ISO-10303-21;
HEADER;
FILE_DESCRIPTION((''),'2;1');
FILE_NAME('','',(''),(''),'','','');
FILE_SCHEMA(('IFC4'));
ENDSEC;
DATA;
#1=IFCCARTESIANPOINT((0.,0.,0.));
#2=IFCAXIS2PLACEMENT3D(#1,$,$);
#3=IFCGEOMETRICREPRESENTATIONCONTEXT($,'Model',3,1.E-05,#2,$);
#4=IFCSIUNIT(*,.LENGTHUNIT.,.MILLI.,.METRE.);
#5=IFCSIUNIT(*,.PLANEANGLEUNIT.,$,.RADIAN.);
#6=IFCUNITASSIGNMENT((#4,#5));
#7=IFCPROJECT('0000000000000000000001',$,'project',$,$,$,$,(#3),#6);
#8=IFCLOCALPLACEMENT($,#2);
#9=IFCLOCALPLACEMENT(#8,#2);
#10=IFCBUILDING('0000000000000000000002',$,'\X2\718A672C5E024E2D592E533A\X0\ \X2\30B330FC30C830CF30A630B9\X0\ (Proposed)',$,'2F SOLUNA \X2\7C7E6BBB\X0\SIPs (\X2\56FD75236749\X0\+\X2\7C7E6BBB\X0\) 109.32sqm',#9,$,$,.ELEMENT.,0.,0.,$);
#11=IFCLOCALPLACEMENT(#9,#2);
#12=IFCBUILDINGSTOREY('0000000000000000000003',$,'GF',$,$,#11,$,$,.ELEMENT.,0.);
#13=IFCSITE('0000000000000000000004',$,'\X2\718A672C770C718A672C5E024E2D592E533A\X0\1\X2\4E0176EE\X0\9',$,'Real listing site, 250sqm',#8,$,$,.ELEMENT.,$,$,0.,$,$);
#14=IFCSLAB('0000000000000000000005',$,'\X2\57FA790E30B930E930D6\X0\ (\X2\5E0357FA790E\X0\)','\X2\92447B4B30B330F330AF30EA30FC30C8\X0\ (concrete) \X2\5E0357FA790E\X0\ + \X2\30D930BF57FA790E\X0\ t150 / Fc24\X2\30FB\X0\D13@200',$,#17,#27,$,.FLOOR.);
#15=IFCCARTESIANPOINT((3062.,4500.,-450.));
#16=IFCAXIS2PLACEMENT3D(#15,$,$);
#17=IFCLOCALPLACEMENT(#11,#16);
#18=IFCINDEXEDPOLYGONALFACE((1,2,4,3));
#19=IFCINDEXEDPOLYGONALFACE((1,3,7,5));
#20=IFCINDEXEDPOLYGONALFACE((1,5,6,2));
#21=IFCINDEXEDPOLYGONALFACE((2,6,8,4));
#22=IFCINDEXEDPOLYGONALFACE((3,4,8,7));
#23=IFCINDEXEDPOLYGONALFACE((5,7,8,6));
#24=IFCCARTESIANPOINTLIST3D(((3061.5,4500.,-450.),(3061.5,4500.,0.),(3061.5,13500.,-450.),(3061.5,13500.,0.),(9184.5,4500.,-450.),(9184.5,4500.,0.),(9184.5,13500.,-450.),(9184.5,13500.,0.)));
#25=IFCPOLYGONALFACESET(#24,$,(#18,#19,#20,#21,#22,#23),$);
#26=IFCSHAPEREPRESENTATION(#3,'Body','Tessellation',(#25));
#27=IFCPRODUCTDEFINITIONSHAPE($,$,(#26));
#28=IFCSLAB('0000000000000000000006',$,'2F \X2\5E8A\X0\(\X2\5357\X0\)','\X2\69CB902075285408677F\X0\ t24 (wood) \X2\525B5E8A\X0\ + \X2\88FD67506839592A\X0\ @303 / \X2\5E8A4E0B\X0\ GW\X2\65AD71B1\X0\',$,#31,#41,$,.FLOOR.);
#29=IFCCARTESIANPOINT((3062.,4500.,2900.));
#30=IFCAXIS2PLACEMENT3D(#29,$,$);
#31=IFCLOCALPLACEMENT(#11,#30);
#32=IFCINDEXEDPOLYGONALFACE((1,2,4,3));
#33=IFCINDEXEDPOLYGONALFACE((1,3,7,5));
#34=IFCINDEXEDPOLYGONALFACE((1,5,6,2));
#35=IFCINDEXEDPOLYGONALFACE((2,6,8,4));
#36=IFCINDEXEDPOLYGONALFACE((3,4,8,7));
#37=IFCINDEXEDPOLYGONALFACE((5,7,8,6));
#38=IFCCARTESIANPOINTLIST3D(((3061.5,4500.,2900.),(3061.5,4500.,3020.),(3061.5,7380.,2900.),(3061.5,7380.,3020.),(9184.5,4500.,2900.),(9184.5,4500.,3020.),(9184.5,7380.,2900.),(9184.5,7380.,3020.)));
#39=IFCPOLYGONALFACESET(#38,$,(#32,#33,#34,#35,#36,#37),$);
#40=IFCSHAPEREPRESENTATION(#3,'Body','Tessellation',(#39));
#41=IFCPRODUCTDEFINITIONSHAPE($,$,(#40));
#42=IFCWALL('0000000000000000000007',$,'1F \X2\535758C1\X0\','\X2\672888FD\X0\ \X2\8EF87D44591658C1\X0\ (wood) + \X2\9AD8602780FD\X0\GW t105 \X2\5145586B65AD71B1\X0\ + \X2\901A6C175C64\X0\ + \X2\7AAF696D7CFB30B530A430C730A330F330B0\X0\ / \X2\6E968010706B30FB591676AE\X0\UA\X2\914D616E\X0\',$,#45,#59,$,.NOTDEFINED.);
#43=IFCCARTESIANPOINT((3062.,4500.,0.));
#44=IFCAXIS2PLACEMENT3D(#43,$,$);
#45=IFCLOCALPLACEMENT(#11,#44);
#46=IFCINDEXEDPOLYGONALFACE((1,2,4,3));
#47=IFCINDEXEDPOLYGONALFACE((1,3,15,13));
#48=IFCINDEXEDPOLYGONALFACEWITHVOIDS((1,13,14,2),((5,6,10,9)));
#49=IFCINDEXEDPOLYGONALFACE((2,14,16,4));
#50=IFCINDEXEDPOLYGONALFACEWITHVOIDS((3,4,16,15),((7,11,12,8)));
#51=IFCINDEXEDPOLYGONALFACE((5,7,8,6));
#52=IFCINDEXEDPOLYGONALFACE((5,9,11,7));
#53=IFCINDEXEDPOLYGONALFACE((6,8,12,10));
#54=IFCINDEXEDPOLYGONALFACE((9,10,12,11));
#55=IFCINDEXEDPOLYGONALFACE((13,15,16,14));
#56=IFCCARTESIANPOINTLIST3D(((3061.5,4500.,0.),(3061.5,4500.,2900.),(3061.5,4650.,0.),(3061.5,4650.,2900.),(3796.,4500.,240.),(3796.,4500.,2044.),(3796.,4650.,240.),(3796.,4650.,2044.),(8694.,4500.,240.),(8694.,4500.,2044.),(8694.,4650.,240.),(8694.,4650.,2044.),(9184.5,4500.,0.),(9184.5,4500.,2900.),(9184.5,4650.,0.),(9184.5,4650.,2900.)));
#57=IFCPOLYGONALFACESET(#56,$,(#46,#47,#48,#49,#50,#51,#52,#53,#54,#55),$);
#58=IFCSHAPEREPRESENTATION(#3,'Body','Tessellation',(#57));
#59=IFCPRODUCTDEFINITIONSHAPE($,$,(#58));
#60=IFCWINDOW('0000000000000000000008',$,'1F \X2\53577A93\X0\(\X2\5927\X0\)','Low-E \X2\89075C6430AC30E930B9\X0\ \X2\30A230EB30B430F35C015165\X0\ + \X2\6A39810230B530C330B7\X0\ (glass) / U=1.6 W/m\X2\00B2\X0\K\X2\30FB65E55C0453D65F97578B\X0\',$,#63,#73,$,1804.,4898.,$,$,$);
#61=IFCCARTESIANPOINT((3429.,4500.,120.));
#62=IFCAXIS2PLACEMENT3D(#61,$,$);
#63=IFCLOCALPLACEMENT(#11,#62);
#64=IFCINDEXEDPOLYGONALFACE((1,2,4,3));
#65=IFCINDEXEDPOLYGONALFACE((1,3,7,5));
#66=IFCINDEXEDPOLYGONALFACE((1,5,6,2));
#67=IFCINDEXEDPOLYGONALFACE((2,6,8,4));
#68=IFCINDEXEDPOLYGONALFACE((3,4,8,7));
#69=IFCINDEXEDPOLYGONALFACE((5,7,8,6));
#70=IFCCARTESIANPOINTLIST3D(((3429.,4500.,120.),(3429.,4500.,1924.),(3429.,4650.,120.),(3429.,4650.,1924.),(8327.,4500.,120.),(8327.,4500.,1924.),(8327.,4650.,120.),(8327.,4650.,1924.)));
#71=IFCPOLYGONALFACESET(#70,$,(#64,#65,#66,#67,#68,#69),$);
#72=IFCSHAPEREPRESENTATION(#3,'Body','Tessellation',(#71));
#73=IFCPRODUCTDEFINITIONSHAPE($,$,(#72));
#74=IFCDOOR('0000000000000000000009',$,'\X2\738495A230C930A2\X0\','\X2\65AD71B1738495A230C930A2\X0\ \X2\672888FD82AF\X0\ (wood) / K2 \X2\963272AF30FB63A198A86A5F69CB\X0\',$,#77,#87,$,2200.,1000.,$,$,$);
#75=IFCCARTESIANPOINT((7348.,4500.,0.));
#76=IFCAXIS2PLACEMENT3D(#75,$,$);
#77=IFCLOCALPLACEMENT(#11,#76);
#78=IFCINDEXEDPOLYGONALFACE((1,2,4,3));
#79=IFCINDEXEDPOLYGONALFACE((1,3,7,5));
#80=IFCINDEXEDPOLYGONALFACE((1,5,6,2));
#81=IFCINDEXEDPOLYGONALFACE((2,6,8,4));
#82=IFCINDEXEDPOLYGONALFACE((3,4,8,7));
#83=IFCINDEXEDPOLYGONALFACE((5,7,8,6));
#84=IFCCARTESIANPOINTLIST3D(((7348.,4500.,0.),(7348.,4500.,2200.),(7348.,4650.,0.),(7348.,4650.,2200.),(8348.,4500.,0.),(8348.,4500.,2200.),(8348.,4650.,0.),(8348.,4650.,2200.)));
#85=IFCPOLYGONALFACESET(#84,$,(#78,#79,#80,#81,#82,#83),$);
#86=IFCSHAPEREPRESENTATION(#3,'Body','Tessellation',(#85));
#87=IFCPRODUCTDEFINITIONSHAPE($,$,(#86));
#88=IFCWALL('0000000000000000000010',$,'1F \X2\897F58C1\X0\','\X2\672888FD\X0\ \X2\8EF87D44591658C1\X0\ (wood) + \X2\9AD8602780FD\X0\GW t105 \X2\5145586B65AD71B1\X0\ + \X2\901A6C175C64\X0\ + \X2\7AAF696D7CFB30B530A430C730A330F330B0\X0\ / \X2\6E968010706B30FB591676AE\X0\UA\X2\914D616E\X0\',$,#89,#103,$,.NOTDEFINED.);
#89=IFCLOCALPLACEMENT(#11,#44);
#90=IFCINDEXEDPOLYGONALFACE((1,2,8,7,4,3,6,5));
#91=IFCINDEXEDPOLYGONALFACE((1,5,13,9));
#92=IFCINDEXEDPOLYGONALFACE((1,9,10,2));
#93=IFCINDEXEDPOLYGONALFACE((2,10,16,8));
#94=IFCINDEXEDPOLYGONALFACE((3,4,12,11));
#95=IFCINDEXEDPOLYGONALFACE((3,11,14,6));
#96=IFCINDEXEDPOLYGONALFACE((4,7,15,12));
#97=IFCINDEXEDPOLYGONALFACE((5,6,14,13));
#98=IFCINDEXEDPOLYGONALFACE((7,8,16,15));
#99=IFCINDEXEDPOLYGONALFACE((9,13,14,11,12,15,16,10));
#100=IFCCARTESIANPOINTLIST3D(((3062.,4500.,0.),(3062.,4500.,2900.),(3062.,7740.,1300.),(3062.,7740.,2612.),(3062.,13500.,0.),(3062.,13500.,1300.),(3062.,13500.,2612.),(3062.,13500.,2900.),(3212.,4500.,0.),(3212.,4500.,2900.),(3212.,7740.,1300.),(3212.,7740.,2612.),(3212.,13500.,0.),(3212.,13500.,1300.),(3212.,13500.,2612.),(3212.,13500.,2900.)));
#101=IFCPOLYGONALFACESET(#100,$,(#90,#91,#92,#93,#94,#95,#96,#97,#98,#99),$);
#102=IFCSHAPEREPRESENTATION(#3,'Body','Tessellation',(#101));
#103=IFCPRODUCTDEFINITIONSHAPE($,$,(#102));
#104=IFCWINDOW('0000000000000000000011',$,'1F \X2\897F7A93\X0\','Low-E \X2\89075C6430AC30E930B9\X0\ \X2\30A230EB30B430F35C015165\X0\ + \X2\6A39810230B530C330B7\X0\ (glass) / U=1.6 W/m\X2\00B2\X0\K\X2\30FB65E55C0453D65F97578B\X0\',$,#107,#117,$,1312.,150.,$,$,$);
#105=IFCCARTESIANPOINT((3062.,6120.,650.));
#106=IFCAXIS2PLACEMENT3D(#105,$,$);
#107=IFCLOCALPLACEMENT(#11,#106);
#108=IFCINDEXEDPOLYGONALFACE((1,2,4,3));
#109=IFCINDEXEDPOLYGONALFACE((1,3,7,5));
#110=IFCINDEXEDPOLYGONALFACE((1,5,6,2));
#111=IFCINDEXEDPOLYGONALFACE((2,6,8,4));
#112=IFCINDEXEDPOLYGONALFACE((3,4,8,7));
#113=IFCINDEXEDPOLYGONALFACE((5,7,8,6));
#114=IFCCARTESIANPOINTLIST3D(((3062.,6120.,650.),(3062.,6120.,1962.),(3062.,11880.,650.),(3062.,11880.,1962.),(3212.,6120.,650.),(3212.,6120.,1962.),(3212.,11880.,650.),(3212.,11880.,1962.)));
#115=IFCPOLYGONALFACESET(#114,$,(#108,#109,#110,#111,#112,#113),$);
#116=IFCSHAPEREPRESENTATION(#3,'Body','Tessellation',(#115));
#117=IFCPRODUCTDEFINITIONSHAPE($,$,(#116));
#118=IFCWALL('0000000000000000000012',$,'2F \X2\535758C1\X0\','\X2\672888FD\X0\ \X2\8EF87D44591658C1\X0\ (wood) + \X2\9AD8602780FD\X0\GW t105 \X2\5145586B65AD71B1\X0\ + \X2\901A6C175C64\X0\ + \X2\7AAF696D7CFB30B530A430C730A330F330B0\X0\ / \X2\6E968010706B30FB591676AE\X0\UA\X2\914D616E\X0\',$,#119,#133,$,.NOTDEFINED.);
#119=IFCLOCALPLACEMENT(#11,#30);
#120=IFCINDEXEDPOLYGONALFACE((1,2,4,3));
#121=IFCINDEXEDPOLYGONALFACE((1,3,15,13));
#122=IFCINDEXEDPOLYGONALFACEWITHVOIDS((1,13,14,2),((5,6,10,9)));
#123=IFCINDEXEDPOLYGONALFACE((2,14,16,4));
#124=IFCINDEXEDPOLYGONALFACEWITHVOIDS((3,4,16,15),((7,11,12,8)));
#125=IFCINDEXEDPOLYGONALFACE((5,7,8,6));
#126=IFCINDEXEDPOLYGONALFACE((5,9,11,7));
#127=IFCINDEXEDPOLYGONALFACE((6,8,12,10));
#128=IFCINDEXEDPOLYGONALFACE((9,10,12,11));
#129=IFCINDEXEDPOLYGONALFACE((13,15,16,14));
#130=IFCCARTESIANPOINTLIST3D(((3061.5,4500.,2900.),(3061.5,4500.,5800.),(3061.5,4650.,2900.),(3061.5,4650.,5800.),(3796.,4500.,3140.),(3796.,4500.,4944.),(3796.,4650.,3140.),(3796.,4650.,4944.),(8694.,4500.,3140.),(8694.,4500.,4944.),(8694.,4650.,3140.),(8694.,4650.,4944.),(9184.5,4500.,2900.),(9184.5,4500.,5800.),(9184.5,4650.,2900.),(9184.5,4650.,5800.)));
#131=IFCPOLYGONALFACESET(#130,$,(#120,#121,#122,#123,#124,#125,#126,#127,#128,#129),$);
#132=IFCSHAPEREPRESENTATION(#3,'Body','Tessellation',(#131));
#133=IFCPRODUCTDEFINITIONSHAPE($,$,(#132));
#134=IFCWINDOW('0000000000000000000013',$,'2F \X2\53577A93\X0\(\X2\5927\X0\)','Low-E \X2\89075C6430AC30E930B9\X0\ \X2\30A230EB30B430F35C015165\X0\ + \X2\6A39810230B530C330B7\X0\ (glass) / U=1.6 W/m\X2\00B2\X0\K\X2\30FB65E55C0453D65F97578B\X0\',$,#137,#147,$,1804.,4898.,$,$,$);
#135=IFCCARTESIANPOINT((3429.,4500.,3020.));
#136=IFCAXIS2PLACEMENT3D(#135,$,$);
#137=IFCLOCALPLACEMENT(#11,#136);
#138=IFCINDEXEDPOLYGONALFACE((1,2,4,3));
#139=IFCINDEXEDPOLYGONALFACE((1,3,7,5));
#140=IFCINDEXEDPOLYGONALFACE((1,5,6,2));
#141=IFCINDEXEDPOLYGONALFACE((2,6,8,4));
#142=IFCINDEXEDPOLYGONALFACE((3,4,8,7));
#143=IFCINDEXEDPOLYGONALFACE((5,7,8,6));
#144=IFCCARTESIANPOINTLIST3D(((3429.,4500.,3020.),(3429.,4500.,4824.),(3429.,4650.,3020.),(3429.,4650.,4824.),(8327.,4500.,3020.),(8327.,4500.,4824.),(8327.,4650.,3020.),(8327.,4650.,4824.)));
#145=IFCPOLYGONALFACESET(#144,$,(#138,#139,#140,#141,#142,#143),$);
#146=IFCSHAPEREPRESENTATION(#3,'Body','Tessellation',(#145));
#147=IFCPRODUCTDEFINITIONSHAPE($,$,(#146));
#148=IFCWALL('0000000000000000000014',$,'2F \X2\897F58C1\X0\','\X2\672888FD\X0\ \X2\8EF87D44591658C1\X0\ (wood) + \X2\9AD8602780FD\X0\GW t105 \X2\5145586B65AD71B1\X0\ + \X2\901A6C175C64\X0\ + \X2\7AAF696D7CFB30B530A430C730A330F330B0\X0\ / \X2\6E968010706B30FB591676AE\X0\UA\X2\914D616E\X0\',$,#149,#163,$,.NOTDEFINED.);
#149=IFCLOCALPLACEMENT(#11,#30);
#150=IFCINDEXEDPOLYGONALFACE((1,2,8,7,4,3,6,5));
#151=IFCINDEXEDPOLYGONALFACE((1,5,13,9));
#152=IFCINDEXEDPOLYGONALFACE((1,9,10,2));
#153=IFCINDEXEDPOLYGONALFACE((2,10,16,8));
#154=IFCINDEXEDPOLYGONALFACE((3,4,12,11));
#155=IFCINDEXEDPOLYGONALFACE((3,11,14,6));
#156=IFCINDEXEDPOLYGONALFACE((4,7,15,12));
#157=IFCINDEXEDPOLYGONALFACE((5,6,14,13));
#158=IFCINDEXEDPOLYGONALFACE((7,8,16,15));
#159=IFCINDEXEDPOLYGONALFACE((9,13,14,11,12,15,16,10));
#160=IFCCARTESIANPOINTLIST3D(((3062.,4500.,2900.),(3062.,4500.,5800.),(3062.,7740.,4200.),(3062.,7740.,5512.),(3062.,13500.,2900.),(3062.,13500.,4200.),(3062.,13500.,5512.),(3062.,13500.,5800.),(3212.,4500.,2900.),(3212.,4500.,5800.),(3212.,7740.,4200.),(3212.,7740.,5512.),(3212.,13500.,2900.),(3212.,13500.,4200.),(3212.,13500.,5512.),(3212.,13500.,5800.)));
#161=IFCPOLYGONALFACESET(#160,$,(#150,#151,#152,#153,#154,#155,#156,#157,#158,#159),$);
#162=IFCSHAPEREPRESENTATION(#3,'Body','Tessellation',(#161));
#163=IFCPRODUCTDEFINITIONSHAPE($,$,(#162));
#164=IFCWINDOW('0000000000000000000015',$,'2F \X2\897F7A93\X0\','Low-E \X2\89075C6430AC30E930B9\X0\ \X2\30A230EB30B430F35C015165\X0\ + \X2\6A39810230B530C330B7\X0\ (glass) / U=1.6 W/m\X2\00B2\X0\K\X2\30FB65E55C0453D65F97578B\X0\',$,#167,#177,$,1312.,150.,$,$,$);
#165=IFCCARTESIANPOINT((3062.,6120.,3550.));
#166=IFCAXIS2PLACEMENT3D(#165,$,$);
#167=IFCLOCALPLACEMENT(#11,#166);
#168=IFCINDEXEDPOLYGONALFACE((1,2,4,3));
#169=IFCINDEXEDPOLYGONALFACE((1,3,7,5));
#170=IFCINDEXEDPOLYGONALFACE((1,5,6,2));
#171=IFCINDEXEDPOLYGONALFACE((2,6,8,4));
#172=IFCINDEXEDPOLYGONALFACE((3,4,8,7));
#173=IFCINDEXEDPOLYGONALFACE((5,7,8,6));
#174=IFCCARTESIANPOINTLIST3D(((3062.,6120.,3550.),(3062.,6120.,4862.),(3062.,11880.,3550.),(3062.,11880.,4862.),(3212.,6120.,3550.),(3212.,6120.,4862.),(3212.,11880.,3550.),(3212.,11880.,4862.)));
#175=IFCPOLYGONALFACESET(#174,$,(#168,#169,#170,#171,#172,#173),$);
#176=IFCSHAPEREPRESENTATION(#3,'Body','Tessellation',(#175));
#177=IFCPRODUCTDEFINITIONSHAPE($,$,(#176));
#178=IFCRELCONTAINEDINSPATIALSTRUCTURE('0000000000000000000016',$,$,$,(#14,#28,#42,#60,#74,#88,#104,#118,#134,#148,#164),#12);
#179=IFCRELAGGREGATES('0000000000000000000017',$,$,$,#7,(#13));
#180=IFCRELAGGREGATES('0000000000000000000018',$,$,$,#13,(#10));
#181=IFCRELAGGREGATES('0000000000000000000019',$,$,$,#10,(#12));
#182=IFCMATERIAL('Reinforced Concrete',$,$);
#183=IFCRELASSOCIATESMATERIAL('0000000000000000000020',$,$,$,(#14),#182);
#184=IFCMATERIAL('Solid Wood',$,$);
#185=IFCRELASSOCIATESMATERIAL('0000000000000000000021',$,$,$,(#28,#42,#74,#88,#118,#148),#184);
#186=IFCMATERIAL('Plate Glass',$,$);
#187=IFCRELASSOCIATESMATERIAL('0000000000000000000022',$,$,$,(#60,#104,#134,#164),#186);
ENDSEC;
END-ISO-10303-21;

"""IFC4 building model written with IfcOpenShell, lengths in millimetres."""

from ifc_helpers import new_model, si_unit, frame, frame_2d, origin, place, context, project, spatial, rectangle, extrude, material, element, fill, save


model = new_model("IFC4")

# Units and contexts
model_context = context("Model", 3, precision=1e-05, world=origin())
ifc_project = project(units=[si_unit("LENGTHUNIT", "METRE", prefix="MILLI"), si_unit("PLANEANGLEUNIT", "RADIAN")], contexts=[model_context])

# Site, building, storey
site_placement = place(None, origin())
site = spatial("IfcSite", under=ifc_project, at=site_placement, Name="熊本県熊本市中央区1丁目9", ObjectType="Real listing site, 250sqm", CompositionType="ELEMENT", RefElevation=0.0)
building_placement = place(site_placement, origin())
building = spatial("IfcBuilding", under=site, at=building_placement, Name="熊本市中央区 コートハウス (Proposed)", ObjectType="2F SOLUNA 籾殻SIPs (国産杉+籾殻) 109.32sqm", CompositionType="ELEMENT", ElevationOfRefHeight=0.0, ElevationOfTerrain=0.0)
storey_placement = place(building_placement, origin())
storey = spatial("IfcBuildingStorey", under=building, at=storey_placement, Name="GF", CompositionType="ELEMENT", Elevation=0.0)

# Slabs
ifc_material_1 = material(Name="Reinforced Concrete")
slab_1_placement = place(storey_placement, frame((3062.0, 4500.0, -450.0)))
element("IfcSlab", 1, at=slab_1_placement, inside=storey, material=ifc_material_1, Name="基礎スラブ (布基礎)", Description="鉄筋コンクリート (concrete) 布基礎 + ベタ基礎 t150 / Fc24・D13@200", PredefinedType="FLOOR", context=model_context, shape_type="SweptSolid", body=[
    extrude(rectangle(XDim=6123.0, YDim=9000.0, at=frame_2d((3061.0, 4500.0))), frame((3062.0, 4500.0, -450.0)), (0.0, 0.0, 1.0), 450.0),
])
ifc_material_2 = material(Name="Solid Wood")
slab_2_placement = place(storey_placement, frame((3062.0, 4500.0, 2900.0)))
element("IfcSlab", 2, at=slab_2_placement, inside=storey, material=ifc_material_2, Name="2F 床(南)", Description="構造用合板 t24 (wood) 剛床 + 製材根太 @303 / 床下 GW断熱", PredefinedType="FLOOR", context=model_context, shape_type="SweptSolid", body=[
    extrude(rectangle(XDim=6123.0, YDim=2880.0, at=frame_2d((3061.0, 1440.0))), frame((3062.0, 4500.0, 2900.0)), (0.0, 0.0, 1.0), 120.0),
])

# Wall, openings, window, door
wall_1_placement = place(storey_placement, frame((3062.0, 4500.0, 0.0)))
wall_1 = element("IfcWall", 3, at=wall_1_placement, inside=storey, material=ifc_material_2, Name="1F 南壁", Description="木製 軸組外壁 (wood) + 高性能GW t105 充填断熱 + 通気層 + 窯業系サイディング / 準耐火・外皮UA配慮", PredefinedType="NOTDEFINED", context=model_context, shape_type="SweptSolid", body=[
    extrude(rectangle(XDim=6123.0, YDim=150.0, at=frame_2d((3061.0, 75.0))), frame((3062.0, 4500.0, 0.0)), (0.0, 0.0, 1.0), 2900.0),
])
opening_1_placement = place(storey_placement, frame((3429.0, 4500.0, 120.0)))
opening_1 = element("IfcOpeningElement", 4, at=opening_1_placement, cuts=wall_1, PredefinedType="NOTDEFINED", context=model_context, shape_type="SweptSolid", body=[
    extrude(rectangle(XDim=4898.0, YDim=150.0, at=frame_2d((2449.0, 75.0))), frame((3429.0, 4500.0, 120.0)), (0.0, 0.0, 1.0), 1804.0),
])
opening_2_placement = place(storey_placement, frame((7348.0, 4500.0, 0.0)))
opening_2 = element("IfcOpeningElement", 5, at=opening_2_placement, cuts=wall_1, PredefinedType="NOTDEFINED", context=model_context, shape_type="SweptSolid", body=[
    extrude(rectangle(XDim=1000.0, YDim=150.0, at=frame_2d((500.0, 75.0))), frame((7348.0, 4500.0, 0.0)), (0.0, 0.0, 1.0), 2200.0),
])
ifc_material_3 = material(Name="Plate Glass")
window_1_placement = place(storey_placement, frame((3429.0, 4500.0, 120.0)))
window_1 = element("IfcWindow", 6, at=window_1_placement, inside=storey, material=ifc_material_3, Name="1F 南窓(大)", Description="Low-E 複層ガラス アルゴン封入 + 樹脂サッシ (glass) / U=1.6 W/m²K・日射取得型", OverallHeight=1804.0, OverallWidth=4898.0, context=model_context, shape_type="SweptSolid", body=[
    extrude(rectangle(XDim=4898.0, YDim=150.0, at=frame_2d((2449.0, 75.0))), frame((3429.0, 4500.0, 120.0)), (0.0, 0.0, 1.0), 1804.0),
])
fill(opening_1, window_1)
door_placement = place(storey_placement, frame((7348.0, 4500.0, 0.0)))
door = element("IfcDoor", 7, at=door_placement, inside=storey, material=ifc_material_2, Name="玄関ドア", Description="断熱玄関ドア 木製芯 (wood) / K2 防犯・採風機構", OverallHeight=2200.0, OverallWidth=1000.0, context=model_context, shape_type="SweptSolid", body=[
    extrude(rectangle(XDim=1000.0, YDim=150.0, at=frame_2d((500.0, 75.0))), frame((7348.0, 4500.0, 0.0)), (0.0, 0.0, 1.0), 2200.0),
])
fill(opening_2, door)

# Walls, openings, windows
wall_2_placement = place(storey_placement, frame((3062.0, 4500.0, 0.0)))
wall_2 = element("IfcWall", 8, at=wall_2_placement, inside=storey, material=ifc_material_2, Name="1F 西壁", Description="木製 軸組外壁 (wood) + 高性能GW t105 充填断熱 + 通気層 + 窯業系サイディング / 準耐火・外皮UA配慮", PredefinedType="NOTDEFINED", context=model_context, shape_type="SweptSolid", body=[
    extrude(rectangle(XDim=150.0, YDim=9000.0, at=frame_2d((75.0, 4500.0))), frame((3062.0, 4500.0, 0.0)), (0.0, 0.0, 1.0), 2900.0),
])
opening_3_placement = place(storey_placement, frame((3062.0, 6120.0, 650.0)))
opening_3 = element("IfcOpeningElement", 9, at=opening_3_placement, cuts=wall_2, PredefinedType="NOTDEFINED", context=model_context, shape_type="SweptSolid", body=[
    extrude(rectangle(XDim=150.0, YDim=5760.0, at=frame_2d((75.0, 2880.0))), frame((3062.0, 6120.0, 650.0)), (0.0, 0.0, 1.0), 1312.0),
])
window_2_placement = place(storey_placement, frame((3062.0, 6120.0, 650.0)))
window_2 = element("IfcWindow", 10, at=window_2_placement, inside=storey, material=ifc_material_3, Name="1F 西窓", Description="Low-E 複層ガラス アルゴン封入 + 樹脂サッシ (glass) / U=1.6 W/m²K・日射取得型", OverallHeight=1312.0, OverallWidth=150.0, context=model_context, shape_type="SweptSolid", body=[
    extrude(rectangle(XDim=150.0, YDim=5760.0, at=frame_2d((75.0, 2880.0))), frame((3062.0, 6120.0, 650.0)), (0.0, 0.0, 1.0), 1312.0),
])
fill(opening_3, window_2)
wall_3_placement = place(storey_placement, frame((3062.0, 4500.0, 2900.0)))
wall_3 = element("IfcWall", 11, at=wall_3_placement, inside=storey, material=ifc_material_2, Name="2F 南壁", Description="木製 軸組外壁 (wood) + 高性能GW t105 充填断熱 + 通気層 + 窯業系サイディング / 準耐火・外皮UA配慮", PredefinedType="NOTDEFINED", context=model_context, shape_type="SweptSolid", body=[
    extrude(rectangle(XDim=6123.0, YDim=150.0, at=frame_2d((3061.0, 75.0))), frame((3062.0, 4500.0, 2900.0)), (0.0, 0.0, 1.0), 2900.0),
])
opening_4_placement = place(storey_placement, frame((3429.0, 4500.0, 3020.0)))
opening_4 = element("IfcOpeningElement", 12, at=opening_4_placement, cuts=wall_3, PredefinedType="NOTDEFINED", context=model_context, shape_type="SweptSolid", body=[
    extrude(rectangle(XDim=4898.0, YDim=150.0, at=frame_2d((2449.0, 75.0))), frame((3429.0, 4500.0, 3020.0)), (0.0, 0.0, 1.0), 1804.0),
])
window_3_placement = place(storey_placement, frame((3429.0, 4500.0, 3020.0)))
window_3 = element("IfcWindow", 13, at=window_3_placement, inside=storey, material=ifc_material_3, Name="2F 南窓(大)", Description="Low-E 複層ガラス アルゴン封入 + 樹脂サッシ (glass) / U=1.6 W/m²K・日射取得型", OverallHeight=1804.0, OverallWidth=4898.0, context=model_context, shape_type="SweptSolid", body=[
    extrude(rectangle(XDim=4898.0, YDim=150.0, at=frame_2d((2449.0, 75.0))), frame((3429.0, 4500.0, 3020.0)), (0.0, 0.0, 1.0), 1804.0),
])
fill(opening_4, window_3)
wall_4_placement = place(storey_placement, frame((3062.0, 4500.0, 2900.0)))
wall_4 = element("IfcWall", 14, at=wall_4_placement, inside=storey, material=ifc_material_2, Name="2F 西壁", Description="木製 軸組外壁 (wood) + 高性能GW t105 充填断熱 + 通気層 + 窯業系サイディング / 準耐火・外皮UA配慮", PredefinedType="NOTDEFINED", context=model_context, shape_type="SweptSolid", body=[
    extrude(rectangle(XDim=150.0, YDim=9000.0, at=frame_2d((75.0, 4500.0))), frame((3062.0, 4500.0, 2900.0)), (0.0, 0.0, 1.0), 2900.0),
])
opening_5_placement = place(storey_placement, frame((3062.0, 6120.0, 3550.0)))
opening_5 = element("IfcOpeningElement", 15, at=opening_5_placement, cuts=wall_4, PredefinedType="NOTDEFINED", context=model_context, shape_type="SweptSolid", body=[
    extrude(rectangle(XDim=150.0, YDim=5760.0, at=frame_2d((75.0, 2880.0))), frame((3062.0, 6120.0, 3550.0)), (0.0, 0.0, 1.0), 1312.0),
])
window_4_placement = place(storey_placement, frame((3062.0, 6120.0, 3550.0)))
window_4 = element("IfcWindow", 16, at=window_4_placement, inside=storey, material=ifc_material_3, Name="2F 西窓", Description="Low-E 複層ガラス アルゴン封入 + 樹脂サッシ (glass) / U=1.6 W/m²K・日射取得型", OverallHeight=1312.0, OverallWidth=150.0, context=model_context, shape_type="SweptSolid", body=[
    extrude(rectangle(XDim=150.0, YDim=5760.0, at=frame_2d((75.0, 2880.0))), frame((3062.0, 6120.0, 3550.0)), (0.0, 0.0, 1.0), 1312.0),
])
fill(opening_5, window_4)

save(model, "model.ifc")
